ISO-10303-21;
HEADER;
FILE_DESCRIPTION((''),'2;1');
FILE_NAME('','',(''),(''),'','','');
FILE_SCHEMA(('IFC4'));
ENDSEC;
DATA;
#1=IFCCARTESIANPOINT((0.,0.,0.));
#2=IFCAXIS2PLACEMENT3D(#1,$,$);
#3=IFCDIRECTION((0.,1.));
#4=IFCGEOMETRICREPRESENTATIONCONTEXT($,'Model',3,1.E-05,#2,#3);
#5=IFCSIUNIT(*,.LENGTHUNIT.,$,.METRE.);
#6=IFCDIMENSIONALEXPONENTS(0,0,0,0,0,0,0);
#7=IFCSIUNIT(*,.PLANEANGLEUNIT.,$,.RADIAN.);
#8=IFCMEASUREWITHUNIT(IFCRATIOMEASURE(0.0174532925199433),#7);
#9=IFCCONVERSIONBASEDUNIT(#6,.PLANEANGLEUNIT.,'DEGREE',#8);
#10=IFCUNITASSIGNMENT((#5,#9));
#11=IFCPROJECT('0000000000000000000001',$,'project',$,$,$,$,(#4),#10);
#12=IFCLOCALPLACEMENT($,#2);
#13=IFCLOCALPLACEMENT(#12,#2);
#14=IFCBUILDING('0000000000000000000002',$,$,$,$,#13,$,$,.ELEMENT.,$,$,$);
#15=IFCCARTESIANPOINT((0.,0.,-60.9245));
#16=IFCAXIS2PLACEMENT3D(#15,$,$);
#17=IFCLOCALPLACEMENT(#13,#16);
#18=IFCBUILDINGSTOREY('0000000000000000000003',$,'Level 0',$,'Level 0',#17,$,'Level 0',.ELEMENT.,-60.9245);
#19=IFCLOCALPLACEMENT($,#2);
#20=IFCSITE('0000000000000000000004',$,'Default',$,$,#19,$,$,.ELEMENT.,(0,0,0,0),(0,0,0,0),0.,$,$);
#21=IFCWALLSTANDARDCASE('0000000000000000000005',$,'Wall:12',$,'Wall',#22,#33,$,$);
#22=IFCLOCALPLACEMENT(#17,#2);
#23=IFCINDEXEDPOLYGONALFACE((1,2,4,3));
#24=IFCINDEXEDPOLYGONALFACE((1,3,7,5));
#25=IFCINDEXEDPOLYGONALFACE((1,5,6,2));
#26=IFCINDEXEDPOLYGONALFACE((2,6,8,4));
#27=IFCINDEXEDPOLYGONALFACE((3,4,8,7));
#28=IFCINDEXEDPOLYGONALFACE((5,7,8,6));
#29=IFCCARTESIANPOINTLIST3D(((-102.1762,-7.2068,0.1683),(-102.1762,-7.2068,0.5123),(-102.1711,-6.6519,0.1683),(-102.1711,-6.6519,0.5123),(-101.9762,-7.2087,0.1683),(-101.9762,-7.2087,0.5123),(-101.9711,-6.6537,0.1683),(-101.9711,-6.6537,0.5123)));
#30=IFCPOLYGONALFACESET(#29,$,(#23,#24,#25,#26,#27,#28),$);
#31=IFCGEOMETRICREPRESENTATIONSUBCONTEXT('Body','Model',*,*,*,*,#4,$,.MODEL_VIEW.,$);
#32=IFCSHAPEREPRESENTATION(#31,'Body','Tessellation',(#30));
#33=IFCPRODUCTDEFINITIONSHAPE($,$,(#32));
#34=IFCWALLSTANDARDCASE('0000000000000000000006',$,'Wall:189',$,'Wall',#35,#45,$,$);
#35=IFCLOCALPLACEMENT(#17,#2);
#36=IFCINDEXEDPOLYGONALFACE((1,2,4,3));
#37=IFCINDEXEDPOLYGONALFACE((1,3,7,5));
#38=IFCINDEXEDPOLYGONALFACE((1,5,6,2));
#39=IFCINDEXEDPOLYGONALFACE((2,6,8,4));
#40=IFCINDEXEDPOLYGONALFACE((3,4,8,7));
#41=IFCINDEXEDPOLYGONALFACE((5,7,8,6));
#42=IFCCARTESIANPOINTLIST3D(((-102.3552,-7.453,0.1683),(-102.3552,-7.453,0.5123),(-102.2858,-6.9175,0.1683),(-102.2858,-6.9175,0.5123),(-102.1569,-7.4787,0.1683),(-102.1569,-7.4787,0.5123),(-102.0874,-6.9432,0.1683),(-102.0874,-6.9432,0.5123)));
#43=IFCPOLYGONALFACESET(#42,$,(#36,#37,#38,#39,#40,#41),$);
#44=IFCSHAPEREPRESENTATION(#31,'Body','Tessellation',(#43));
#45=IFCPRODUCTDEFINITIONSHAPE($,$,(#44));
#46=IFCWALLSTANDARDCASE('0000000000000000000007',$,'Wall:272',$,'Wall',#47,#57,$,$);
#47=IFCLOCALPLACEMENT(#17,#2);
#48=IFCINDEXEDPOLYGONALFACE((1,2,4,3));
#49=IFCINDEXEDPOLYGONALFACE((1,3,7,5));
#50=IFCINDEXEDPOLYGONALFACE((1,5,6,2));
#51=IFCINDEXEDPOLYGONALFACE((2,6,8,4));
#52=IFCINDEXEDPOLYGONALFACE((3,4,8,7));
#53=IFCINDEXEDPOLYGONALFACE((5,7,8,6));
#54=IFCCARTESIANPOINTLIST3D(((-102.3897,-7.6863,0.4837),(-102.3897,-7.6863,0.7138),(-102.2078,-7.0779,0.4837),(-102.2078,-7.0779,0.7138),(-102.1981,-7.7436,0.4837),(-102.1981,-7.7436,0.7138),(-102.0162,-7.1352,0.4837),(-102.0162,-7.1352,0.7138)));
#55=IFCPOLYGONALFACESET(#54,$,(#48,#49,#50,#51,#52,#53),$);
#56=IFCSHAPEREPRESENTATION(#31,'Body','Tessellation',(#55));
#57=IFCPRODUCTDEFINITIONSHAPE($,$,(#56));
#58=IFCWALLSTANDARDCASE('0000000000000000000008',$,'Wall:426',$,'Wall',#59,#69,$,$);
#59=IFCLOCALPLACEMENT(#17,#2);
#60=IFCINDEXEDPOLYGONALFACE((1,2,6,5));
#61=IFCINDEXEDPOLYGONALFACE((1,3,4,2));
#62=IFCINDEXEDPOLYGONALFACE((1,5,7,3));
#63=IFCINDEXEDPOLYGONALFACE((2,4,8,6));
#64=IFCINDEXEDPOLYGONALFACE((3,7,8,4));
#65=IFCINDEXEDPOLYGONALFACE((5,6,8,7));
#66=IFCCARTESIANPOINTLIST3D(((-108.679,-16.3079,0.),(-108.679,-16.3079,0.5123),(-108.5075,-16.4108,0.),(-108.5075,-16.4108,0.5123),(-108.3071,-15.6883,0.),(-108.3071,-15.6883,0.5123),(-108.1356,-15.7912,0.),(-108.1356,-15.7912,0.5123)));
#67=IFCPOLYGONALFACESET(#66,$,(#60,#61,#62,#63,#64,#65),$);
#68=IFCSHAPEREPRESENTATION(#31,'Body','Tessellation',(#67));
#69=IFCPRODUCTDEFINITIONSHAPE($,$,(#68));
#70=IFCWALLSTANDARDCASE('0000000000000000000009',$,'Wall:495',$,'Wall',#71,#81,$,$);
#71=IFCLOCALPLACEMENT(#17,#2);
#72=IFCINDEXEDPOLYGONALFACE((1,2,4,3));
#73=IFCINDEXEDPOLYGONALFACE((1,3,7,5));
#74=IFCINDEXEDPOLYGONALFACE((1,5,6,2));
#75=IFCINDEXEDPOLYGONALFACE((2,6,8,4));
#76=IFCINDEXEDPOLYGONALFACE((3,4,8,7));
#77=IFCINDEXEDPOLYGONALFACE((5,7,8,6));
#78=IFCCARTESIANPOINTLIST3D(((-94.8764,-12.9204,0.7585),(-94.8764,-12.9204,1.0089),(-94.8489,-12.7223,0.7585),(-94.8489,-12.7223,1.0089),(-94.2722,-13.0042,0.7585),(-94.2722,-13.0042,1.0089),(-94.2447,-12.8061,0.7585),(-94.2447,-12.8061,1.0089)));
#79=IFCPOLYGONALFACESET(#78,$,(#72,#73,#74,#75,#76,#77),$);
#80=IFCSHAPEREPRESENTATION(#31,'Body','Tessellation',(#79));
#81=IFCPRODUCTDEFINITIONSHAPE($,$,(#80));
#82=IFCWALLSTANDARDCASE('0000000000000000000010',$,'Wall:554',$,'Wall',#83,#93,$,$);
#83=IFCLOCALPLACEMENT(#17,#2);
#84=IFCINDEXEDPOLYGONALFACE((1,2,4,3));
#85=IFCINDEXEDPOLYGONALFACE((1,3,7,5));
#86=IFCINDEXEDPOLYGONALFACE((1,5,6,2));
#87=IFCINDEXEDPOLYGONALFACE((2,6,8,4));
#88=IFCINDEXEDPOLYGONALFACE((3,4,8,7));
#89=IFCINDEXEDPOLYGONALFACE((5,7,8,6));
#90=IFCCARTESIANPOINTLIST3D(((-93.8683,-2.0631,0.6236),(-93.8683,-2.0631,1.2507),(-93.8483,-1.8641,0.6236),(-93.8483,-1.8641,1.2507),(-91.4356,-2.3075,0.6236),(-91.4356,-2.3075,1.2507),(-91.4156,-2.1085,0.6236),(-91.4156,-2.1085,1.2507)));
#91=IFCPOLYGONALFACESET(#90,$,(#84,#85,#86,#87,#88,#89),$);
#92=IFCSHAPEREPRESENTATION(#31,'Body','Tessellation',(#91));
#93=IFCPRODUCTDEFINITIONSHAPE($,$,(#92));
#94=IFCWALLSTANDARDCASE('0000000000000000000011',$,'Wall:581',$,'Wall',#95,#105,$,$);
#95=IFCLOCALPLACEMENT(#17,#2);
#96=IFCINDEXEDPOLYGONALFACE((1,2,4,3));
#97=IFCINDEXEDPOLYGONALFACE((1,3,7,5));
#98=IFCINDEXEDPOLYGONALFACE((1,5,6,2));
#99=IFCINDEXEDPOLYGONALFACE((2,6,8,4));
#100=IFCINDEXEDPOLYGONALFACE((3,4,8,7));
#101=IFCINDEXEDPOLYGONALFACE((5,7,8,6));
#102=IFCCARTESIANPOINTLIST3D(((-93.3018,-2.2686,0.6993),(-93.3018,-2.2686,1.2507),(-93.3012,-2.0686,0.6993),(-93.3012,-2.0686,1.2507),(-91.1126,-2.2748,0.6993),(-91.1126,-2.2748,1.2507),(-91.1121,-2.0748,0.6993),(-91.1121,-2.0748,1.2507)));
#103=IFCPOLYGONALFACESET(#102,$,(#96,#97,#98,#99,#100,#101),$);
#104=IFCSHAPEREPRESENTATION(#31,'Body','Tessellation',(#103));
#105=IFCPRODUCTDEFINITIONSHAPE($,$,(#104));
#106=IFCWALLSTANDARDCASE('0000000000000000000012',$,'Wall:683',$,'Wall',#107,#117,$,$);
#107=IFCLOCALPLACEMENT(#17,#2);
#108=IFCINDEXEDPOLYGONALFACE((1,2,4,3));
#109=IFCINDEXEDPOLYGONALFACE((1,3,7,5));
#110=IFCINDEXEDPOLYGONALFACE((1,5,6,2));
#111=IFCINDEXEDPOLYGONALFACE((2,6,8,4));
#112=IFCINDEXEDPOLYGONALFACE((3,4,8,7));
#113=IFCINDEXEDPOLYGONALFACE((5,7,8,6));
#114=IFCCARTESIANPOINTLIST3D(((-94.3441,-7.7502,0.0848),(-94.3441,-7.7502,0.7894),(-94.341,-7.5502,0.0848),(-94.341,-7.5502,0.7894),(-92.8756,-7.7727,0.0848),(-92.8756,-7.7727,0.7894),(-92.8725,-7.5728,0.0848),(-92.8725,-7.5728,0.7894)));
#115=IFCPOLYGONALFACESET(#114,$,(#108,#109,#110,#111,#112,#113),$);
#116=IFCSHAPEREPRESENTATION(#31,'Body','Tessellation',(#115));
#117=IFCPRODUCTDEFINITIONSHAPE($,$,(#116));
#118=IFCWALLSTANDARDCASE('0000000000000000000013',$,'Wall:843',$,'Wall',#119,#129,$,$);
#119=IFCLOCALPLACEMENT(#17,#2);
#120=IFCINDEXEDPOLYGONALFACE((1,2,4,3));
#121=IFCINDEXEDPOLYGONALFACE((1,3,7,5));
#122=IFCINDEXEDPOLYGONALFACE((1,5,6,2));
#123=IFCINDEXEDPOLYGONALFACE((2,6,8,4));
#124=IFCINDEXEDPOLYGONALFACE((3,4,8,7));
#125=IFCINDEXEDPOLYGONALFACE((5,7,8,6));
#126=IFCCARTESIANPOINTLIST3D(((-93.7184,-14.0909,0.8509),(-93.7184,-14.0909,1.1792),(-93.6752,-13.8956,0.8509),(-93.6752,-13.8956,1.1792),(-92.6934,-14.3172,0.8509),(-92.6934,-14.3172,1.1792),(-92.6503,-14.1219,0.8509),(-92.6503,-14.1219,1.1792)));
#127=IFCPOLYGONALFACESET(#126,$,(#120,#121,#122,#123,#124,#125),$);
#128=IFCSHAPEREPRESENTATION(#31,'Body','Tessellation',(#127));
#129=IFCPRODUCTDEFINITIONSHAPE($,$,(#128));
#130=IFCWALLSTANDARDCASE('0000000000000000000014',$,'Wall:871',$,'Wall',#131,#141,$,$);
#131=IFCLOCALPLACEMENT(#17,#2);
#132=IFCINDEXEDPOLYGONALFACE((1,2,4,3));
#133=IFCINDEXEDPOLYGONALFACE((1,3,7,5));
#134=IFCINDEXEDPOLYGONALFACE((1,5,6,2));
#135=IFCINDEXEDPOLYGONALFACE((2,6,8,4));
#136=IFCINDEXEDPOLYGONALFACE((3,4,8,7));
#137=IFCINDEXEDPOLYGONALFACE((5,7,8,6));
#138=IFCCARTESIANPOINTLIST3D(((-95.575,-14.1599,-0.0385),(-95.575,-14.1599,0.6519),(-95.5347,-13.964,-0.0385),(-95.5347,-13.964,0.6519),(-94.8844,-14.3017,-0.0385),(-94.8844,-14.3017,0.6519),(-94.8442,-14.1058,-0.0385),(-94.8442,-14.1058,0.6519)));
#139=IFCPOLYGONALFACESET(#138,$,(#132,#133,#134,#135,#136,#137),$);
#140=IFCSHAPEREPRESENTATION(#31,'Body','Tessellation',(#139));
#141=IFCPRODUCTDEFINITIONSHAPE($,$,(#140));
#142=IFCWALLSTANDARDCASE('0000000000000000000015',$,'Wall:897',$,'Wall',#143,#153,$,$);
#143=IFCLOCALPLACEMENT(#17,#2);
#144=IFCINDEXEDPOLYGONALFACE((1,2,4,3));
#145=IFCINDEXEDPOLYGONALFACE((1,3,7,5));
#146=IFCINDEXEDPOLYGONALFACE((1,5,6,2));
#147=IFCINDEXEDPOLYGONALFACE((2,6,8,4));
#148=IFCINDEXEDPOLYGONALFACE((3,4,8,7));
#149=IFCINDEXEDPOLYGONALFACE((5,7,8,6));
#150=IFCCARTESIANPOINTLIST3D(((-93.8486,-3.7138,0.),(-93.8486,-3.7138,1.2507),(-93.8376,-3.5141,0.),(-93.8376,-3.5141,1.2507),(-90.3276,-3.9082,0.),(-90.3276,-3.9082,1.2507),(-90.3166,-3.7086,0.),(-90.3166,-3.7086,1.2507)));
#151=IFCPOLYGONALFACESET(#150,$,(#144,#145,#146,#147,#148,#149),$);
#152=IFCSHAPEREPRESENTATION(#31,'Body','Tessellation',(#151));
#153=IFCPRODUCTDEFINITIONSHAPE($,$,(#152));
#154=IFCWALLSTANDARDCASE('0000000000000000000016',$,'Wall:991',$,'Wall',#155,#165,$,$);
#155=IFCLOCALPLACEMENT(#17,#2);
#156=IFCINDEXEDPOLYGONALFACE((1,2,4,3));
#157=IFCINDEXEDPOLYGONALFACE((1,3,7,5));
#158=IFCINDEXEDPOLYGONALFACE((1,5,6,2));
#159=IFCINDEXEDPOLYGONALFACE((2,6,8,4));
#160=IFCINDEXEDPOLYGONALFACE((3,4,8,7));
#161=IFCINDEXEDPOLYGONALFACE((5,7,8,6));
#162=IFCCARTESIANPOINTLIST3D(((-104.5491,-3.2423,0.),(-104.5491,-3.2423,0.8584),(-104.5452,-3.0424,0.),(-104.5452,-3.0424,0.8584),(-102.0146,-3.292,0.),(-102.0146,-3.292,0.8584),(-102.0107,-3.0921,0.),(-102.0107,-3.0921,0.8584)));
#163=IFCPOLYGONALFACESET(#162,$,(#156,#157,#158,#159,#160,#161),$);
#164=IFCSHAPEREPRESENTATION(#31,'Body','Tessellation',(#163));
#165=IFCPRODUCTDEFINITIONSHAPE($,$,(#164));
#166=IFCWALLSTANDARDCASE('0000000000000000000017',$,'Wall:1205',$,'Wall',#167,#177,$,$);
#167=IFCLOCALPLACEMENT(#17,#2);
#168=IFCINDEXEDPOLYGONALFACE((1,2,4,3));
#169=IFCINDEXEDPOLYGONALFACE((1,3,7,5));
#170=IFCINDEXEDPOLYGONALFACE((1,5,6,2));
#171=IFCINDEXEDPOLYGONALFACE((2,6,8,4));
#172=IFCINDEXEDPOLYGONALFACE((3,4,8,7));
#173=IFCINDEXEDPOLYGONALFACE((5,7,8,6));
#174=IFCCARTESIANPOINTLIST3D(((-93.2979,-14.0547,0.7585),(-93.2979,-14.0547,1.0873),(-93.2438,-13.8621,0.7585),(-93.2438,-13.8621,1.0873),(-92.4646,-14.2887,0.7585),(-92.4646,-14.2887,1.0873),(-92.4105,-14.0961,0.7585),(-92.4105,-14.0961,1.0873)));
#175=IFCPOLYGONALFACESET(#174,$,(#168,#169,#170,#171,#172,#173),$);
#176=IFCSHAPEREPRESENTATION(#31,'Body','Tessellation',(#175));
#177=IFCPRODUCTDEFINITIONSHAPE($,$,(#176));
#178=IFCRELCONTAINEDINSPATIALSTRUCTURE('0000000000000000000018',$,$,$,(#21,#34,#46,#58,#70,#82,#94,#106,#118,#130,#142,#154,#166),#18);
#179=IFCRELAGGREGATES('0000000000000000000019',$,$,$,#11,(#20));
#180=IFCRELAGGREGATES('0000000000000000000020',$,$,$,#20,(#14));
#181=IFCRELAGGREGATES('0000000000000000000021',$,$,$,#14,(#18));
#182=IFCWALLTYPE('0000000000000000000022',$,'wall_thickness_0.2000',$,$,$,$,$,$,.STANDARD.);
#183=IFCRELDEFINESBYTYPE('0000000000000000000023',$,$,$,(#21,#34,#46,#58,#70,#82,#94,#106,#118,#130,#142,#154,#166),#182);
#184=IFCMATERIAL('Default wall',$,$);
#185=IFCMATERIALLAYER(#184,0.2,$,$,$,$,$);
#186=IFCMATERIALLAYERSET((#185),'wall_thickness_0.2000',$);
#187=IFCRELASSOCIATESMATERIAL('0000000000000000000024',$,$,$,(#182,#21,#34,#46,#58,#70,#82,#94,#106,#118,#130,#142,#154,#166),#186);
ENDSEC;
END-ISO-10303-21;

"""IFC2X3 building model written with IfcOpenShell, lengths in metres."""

from ifc_helpers import new_model, entity, si_unit, converted_unit, direction, frame, origin, place, context, subcontext, project, spatial, polyline, outline, extrude, material, layer, layer_set, layer_usage, type_object, element, save


model = new_model("IFC2X3")

# Units and contexts
model_context = context("Model", 3, precision=1e-05, world=origin(), true_north=direction((0.0, 1.0)))
body_context = subcontext(model_context, "Body", "Model", "MODEL_VIEW")
ifc_project = project(units=[si_unit("LENGTHUNIT", "METRE"), converted_unit("PLANEANGLEUNIT", "DEGREE", entity("IfcRatioMeasure", 0.0174532925199433), si_unit("PLANEANGLEUNIT", "RADIAN"), dimensions=[0, 0, 0, 0, 0, 0, 0])], contexts=[model_context])

# Site, building, storey
site_placement = place(None, origin())
site = spatial("IfcSite", under=ifc_project, at=site_placement, Name="Default", CompositionType="ELEMENT", RefLatitude=(0, 0, 0, 0), RefLongitude=(0, 0, 0, 0), RefElevation=0.0)
placement_1 = place(None, origin())
building_placement = place(placement_1, origin())
building = spatial("IfcBuilding", under=site, at=building_placement, CompositionType="ELEMENT")
storey_placement = place(building_placement, frame((0.0, 0.0, -60.9245)))
storey = spatial("IfcBuildingStorey", under=building, at=storey_placement, Name="Level 0", ObjectType="Level 0", LongName="Level 0", CompositionType="ELEMENT", Elevation=-60.9245)

# Walls
ifc_material = material(Name="Default wall")
ifc_layer = layer(ifc_material, 0.2)
ifc_layer_set = layer_set([ifc_layer], Name="wall_thickness_0.2000")
ifc_layer_usage = layer_usage(ifc_layer_set, "AXIS2", "POSITIVE", -0.1)
wall_type = type_object("IfcWallType", Name="wall_thickness_0.2000", PredefinedType="STANDARD", material=ifc_layer_set)
placement_2 = place(building_placement, frame((0.0, 0.0, -60.7562)))
wall_1_placement = place(placement_2, frame((-102.0711, -6.6528, 0.0), z_axis=(0.0, 0.0, 1.0), x_axis=(-0.009224, -0.999957, 0.0)))
element("IfcWallStandardCase", 1, at=wall_1_placement, inside=storey, type_object=wall_type, material=ifc_layer_usage, Name="Wall:12", ObjectType="Wall", context=body_context, shape_type="SweptSolid", body=[
    extrude(outline(polyline([(0.555, -0.1), (0.555, 0.1), (0.0, 0.1), (0.0, -0.1), (0.555, -0.1)])), origin(), (0.0, 0.0, 1.0), 0.3439),
])
placement_3 = place(building_placement, frame((0.0, 0.0, -60.7562)))
wall_2_placement = place(placement_3, frame((-102.2561, -7.4659, 0.0), z_axis=(0.0, 0.0, 1.0), x_axis=(0.128669, 0.991688, 0.0)))
element("IfcWallStandardCase", 2, at=wall_2_placement, inside=storey, type_object=wall_type, material=ifc_layer_usage, Name="Wall:189", ObjectType="Wall", context=body_context, shape_type="SweptSolid", body=[
    extrude(outline(polyline([(0.54, -0.1), (0.54, 0.1), (0.0, 0.1), (0.0, -0.1), (0.54, -0.1)])), origin(), (0.0, 0.0, 1.0), 0.3439),
])
placement_4 = place(building_placement, frame((0.0, 0.0, -60.4408)))
wall_3_placement = place(placement_4, frame((-102.2939, -7.715, 0.0), z_axis=(0.0, 0.0, 1.0), x_axis=(0.286384, 0.958115, 0.0)))
element("IfcWallStandardCase", 3, at=wall_3_placement, inside=storey, type_object=wall_type, material=ifc_layer_usage, Name="Wall:272", ObjectType="Wall", context=body_context, shape_type="SweptSolid", body=[
    extrude(outline(polyline([(0.635, -0.1), (0.635, 0.1), (0.0, 0.1), (0.0, -0.1), (0.635, -0.1)])), origin(), (0.0, 0.0, 1.0), 0.23),
])
wall_4_placement = place(storey_placement, frame((-108.5932, -16.3594, 0.0), z_axis=(0.0, 0.0, 1.0), x_axis=(0.514548, 0.857462, 0.0)))
element("IfcWallStandardCase", 4, at=wall_4_placement, inside=storey, type_object=wall_type, material=ifc_layer_usage, Name="Wall:426", ObjectType="Wall", context=body_context, shape_type="SweptSolid", body=[
    extrude(outline(polyline([(0.7226, -0.1), (0.7226, 0.1), (0.0, 0.1), (0.0, -0.1), (0.7226, -0.1)])), origin(), (0.0, 0.0, 1.0), 0.5123),
])
placement_5 = place(building_placement, frame((0.0, 0.0, -60.166)))
wall_5_placement = place(placement_5, frame((-94.8627, -12.8213, 0.0), z_axis=(0.0, 0.0, 1.0), x_axis=(0.990514, -0.137411, 0.0)))
element("IfcWallStandardCase", 5, at=wall_5_placement, inside=storey, type_object=wall_type, material=ifc_layer_usage, Name="Wall:495", ObjectType="Wall", context=body_context, shape_type="SweptSolid", body=[
    extrude(outline(polyline([(0.61, -0.1), (0.61, 0.1), (0.0, 0.1), (0.0, -0.1), (0.61, -0.1)])), origin(), (0.0, 0.0, 1.0), 0.2504),
])
placement_6 = place(building_placement, frame((0.0, 0.0, -60.3009)))
wall_6_placement = place(placement_6, frame((-93.8583, -1.9636, 0.0), z_axis=(0.0, 0.0, 1.0), x_axis=(0.994995, -0.099926, 0.0)))
element("IfcWallStandardCase", 6, at=wall_6_placement, inside=storey, type_object=wall_type, material=ifc_layer_usage, Name="Wall:554", ObjectType="Wall", context=body_context, shape_type="SweptSolid", body=[
    extrude(outline(polyline([(2.445, -0.1), (2.445, 0.1), (0.0, 0.1), (0.0, -0.1), (2.445, -0.1)])), origin(), (0.0, 0.0, 1.0), 0.6271),
])
placement_7 = place(building_placement, frame((0.0, 0.0, -60.2252)))
wall_7_placement = place(placement_7, frame((-93.3015, -2.1686, 0.0), z_axis=(0.0, 0.0, 1.0), x_axis=(0.999996, -0.002861, 0.0)))
element("IfcWallStandardCase", 7, at=wall_7_placement, inside=storey, type_object=wall_type, material=ifc_layer_usage, Name="Wall:581", ObjectType="Wall", context=body_context, shape_type="SweptSolid", body=[
    extrude(outline(polyline([(2.1891, -0.1), (2.1891, 0.1), (0.0, 0.1), (0.0, -0.1), (2.1891, -0.1)])), origin(), (0.0, 0.0, 1.0), 0.5514),
])
placement_8 = place(building_placement, frame((0.0, 0.0, -60.8397)))
wall_8_placement = place(placement_8, frame((-94.3425, -7.6502, 0.0), z_axis=(0.0, 0.0, 1.0), x_axis=(0.999882, -0.015346, 0.0)))
element("IfcWallStandardCase", 8, at=wall_8_placement, inside=storey, type_object=wall_type, material=ifc_layer_usage, Name="Wall:683", ObjectType="Wall", context=body_context, shape_type="SweptSolid", body=[
    extrude(outline(polyline([(1.4687, -0.1), (1.4687, 0.1), (0.0, 0.1), (0.0, -0.1), (1.4687, -0.1)])), origin(), (0.0, 0.0, 1.0), 0.7047),
])
placement_9 = place(building_placement, frame((0.0, 0.0, -60.0736)))
wall_9_placement = place(placement_9, frame((-93.6968, -13.9933, 0.0), z_axis=(0.0, 0.0, 1.0), x_axis=(0.976485, -0.215585, 0.0)))
element("IfcWallStandardCase", 9, at=wall_9_placement, inside=storey, type_object=wall_type, material=ifc_layer_usage, Name="Wall:843", ObjectType="Wall", context=body_context, shape_type="SweptSolid", body=[
    extrude(outline(polyline([(1.0496, -0.1), (1.0496, 0.1), (0.0, 0.1), (0.0, -0.1), (1.0496, -0.1)])), origin(), (0.0, 0.0, 1.0), 0.3283),
])
placement_10 = place(building_placement, frame((0.0, 0.0, -60.963)))
wall_10_placement = place(placement_10, frame((-94.8643, -14.2038, 0.0), z_axis=(0.0, 0.0, 1.0), x_axis=(-0.979559, 0.201159, 0.0)))
element("IfcWallStandardCase", 10, at=wall_10_placement, inside=storey, type_object=wall_type, material=ifc_layer_usage, Name="Wall:871", ObjectType="Wall", context=body_context, shape_type="SweptSolid", body=[
    extrude(outline(polyline([(0.705, -0.1), (0.705, 0.1), (0.0, 0.1), (0.0, -0.1), (0.705, -0.1)])), origin(), (0.0, 0.0, 1.0), 0.6904),
])
wall_11_placement = place(storey_placement, frame((-93.8431, -3.6139, 0.0), z_axis=(0.0, 0.0, 1.0), x_axis=(0.998478, -0.055148, 0.0)))
element("IfcWallStandardCase", 11, at=wall_11_placement, inside=storey, type_object=wall_type, material=ifc_layer_usage, Name="Wall:897", ObjectType="Wall", context=body_context, shape_type="SweptSolid", body=[
    extrude(outline(polyline([(3.5264, -0.1), (3.5264, 0.1), (0.0, 0.1), (0.0, -0.1), (3.5264, -0.1)])), origin(), (0.0, 0.0, 1.0), 1.2507),
])
wall_12_placement = place(storey_placement, frame((-104.5471, -3.1423, 0.0), z_axis=(0.0, 0.0, 1.0), x_axis=(0.999808, -0.019602, 0.0)))
element("IfcWallStandardCase", 12, at=wall_12_placement, inside=storey, type_object=wall_type, material=ifc_layer_usage, Name="Wall:991", ObjectType="Wall", context=body_context, shape_type="SweptSolid", body=[
    extrude(outline(polyline([(2.535, -0.1), (2.535, 0.1), (0.0, 0.1), (0.0, -0.1), (2.535, -0.1)])), origin(), (0.0, 0.0, 1.0), 0.8584),
])
placement_11 = place(building_placement, frame((0.0, 0.0, -60.166)))
wall_13_placement = place(placement_11, frame((-93.2709, -13.9584, 0.0), z_axis=(0.0, 0.0, 1.0), x_axis=(0.962751, -0.270391, 0.0)))
element("IfcWallStandardCase", 13, at=wall_13_placement, inside=storey, type_object=wall_type, material=ifc_layer_usage, Name="Wall:1205", ObjectType="Wall", context=body_context, shape_type="SweptSolid", body=[
    extrude(outline(polyline([(0.8656, -0.1), (0.8656, 0.1), (0.0, 0.1), (0.0, -0.1), (0.8656, -0.1)])), origin(), (0.0, 0.0, 1.0), 0.3288),
])

save(model, "model.ifc")
